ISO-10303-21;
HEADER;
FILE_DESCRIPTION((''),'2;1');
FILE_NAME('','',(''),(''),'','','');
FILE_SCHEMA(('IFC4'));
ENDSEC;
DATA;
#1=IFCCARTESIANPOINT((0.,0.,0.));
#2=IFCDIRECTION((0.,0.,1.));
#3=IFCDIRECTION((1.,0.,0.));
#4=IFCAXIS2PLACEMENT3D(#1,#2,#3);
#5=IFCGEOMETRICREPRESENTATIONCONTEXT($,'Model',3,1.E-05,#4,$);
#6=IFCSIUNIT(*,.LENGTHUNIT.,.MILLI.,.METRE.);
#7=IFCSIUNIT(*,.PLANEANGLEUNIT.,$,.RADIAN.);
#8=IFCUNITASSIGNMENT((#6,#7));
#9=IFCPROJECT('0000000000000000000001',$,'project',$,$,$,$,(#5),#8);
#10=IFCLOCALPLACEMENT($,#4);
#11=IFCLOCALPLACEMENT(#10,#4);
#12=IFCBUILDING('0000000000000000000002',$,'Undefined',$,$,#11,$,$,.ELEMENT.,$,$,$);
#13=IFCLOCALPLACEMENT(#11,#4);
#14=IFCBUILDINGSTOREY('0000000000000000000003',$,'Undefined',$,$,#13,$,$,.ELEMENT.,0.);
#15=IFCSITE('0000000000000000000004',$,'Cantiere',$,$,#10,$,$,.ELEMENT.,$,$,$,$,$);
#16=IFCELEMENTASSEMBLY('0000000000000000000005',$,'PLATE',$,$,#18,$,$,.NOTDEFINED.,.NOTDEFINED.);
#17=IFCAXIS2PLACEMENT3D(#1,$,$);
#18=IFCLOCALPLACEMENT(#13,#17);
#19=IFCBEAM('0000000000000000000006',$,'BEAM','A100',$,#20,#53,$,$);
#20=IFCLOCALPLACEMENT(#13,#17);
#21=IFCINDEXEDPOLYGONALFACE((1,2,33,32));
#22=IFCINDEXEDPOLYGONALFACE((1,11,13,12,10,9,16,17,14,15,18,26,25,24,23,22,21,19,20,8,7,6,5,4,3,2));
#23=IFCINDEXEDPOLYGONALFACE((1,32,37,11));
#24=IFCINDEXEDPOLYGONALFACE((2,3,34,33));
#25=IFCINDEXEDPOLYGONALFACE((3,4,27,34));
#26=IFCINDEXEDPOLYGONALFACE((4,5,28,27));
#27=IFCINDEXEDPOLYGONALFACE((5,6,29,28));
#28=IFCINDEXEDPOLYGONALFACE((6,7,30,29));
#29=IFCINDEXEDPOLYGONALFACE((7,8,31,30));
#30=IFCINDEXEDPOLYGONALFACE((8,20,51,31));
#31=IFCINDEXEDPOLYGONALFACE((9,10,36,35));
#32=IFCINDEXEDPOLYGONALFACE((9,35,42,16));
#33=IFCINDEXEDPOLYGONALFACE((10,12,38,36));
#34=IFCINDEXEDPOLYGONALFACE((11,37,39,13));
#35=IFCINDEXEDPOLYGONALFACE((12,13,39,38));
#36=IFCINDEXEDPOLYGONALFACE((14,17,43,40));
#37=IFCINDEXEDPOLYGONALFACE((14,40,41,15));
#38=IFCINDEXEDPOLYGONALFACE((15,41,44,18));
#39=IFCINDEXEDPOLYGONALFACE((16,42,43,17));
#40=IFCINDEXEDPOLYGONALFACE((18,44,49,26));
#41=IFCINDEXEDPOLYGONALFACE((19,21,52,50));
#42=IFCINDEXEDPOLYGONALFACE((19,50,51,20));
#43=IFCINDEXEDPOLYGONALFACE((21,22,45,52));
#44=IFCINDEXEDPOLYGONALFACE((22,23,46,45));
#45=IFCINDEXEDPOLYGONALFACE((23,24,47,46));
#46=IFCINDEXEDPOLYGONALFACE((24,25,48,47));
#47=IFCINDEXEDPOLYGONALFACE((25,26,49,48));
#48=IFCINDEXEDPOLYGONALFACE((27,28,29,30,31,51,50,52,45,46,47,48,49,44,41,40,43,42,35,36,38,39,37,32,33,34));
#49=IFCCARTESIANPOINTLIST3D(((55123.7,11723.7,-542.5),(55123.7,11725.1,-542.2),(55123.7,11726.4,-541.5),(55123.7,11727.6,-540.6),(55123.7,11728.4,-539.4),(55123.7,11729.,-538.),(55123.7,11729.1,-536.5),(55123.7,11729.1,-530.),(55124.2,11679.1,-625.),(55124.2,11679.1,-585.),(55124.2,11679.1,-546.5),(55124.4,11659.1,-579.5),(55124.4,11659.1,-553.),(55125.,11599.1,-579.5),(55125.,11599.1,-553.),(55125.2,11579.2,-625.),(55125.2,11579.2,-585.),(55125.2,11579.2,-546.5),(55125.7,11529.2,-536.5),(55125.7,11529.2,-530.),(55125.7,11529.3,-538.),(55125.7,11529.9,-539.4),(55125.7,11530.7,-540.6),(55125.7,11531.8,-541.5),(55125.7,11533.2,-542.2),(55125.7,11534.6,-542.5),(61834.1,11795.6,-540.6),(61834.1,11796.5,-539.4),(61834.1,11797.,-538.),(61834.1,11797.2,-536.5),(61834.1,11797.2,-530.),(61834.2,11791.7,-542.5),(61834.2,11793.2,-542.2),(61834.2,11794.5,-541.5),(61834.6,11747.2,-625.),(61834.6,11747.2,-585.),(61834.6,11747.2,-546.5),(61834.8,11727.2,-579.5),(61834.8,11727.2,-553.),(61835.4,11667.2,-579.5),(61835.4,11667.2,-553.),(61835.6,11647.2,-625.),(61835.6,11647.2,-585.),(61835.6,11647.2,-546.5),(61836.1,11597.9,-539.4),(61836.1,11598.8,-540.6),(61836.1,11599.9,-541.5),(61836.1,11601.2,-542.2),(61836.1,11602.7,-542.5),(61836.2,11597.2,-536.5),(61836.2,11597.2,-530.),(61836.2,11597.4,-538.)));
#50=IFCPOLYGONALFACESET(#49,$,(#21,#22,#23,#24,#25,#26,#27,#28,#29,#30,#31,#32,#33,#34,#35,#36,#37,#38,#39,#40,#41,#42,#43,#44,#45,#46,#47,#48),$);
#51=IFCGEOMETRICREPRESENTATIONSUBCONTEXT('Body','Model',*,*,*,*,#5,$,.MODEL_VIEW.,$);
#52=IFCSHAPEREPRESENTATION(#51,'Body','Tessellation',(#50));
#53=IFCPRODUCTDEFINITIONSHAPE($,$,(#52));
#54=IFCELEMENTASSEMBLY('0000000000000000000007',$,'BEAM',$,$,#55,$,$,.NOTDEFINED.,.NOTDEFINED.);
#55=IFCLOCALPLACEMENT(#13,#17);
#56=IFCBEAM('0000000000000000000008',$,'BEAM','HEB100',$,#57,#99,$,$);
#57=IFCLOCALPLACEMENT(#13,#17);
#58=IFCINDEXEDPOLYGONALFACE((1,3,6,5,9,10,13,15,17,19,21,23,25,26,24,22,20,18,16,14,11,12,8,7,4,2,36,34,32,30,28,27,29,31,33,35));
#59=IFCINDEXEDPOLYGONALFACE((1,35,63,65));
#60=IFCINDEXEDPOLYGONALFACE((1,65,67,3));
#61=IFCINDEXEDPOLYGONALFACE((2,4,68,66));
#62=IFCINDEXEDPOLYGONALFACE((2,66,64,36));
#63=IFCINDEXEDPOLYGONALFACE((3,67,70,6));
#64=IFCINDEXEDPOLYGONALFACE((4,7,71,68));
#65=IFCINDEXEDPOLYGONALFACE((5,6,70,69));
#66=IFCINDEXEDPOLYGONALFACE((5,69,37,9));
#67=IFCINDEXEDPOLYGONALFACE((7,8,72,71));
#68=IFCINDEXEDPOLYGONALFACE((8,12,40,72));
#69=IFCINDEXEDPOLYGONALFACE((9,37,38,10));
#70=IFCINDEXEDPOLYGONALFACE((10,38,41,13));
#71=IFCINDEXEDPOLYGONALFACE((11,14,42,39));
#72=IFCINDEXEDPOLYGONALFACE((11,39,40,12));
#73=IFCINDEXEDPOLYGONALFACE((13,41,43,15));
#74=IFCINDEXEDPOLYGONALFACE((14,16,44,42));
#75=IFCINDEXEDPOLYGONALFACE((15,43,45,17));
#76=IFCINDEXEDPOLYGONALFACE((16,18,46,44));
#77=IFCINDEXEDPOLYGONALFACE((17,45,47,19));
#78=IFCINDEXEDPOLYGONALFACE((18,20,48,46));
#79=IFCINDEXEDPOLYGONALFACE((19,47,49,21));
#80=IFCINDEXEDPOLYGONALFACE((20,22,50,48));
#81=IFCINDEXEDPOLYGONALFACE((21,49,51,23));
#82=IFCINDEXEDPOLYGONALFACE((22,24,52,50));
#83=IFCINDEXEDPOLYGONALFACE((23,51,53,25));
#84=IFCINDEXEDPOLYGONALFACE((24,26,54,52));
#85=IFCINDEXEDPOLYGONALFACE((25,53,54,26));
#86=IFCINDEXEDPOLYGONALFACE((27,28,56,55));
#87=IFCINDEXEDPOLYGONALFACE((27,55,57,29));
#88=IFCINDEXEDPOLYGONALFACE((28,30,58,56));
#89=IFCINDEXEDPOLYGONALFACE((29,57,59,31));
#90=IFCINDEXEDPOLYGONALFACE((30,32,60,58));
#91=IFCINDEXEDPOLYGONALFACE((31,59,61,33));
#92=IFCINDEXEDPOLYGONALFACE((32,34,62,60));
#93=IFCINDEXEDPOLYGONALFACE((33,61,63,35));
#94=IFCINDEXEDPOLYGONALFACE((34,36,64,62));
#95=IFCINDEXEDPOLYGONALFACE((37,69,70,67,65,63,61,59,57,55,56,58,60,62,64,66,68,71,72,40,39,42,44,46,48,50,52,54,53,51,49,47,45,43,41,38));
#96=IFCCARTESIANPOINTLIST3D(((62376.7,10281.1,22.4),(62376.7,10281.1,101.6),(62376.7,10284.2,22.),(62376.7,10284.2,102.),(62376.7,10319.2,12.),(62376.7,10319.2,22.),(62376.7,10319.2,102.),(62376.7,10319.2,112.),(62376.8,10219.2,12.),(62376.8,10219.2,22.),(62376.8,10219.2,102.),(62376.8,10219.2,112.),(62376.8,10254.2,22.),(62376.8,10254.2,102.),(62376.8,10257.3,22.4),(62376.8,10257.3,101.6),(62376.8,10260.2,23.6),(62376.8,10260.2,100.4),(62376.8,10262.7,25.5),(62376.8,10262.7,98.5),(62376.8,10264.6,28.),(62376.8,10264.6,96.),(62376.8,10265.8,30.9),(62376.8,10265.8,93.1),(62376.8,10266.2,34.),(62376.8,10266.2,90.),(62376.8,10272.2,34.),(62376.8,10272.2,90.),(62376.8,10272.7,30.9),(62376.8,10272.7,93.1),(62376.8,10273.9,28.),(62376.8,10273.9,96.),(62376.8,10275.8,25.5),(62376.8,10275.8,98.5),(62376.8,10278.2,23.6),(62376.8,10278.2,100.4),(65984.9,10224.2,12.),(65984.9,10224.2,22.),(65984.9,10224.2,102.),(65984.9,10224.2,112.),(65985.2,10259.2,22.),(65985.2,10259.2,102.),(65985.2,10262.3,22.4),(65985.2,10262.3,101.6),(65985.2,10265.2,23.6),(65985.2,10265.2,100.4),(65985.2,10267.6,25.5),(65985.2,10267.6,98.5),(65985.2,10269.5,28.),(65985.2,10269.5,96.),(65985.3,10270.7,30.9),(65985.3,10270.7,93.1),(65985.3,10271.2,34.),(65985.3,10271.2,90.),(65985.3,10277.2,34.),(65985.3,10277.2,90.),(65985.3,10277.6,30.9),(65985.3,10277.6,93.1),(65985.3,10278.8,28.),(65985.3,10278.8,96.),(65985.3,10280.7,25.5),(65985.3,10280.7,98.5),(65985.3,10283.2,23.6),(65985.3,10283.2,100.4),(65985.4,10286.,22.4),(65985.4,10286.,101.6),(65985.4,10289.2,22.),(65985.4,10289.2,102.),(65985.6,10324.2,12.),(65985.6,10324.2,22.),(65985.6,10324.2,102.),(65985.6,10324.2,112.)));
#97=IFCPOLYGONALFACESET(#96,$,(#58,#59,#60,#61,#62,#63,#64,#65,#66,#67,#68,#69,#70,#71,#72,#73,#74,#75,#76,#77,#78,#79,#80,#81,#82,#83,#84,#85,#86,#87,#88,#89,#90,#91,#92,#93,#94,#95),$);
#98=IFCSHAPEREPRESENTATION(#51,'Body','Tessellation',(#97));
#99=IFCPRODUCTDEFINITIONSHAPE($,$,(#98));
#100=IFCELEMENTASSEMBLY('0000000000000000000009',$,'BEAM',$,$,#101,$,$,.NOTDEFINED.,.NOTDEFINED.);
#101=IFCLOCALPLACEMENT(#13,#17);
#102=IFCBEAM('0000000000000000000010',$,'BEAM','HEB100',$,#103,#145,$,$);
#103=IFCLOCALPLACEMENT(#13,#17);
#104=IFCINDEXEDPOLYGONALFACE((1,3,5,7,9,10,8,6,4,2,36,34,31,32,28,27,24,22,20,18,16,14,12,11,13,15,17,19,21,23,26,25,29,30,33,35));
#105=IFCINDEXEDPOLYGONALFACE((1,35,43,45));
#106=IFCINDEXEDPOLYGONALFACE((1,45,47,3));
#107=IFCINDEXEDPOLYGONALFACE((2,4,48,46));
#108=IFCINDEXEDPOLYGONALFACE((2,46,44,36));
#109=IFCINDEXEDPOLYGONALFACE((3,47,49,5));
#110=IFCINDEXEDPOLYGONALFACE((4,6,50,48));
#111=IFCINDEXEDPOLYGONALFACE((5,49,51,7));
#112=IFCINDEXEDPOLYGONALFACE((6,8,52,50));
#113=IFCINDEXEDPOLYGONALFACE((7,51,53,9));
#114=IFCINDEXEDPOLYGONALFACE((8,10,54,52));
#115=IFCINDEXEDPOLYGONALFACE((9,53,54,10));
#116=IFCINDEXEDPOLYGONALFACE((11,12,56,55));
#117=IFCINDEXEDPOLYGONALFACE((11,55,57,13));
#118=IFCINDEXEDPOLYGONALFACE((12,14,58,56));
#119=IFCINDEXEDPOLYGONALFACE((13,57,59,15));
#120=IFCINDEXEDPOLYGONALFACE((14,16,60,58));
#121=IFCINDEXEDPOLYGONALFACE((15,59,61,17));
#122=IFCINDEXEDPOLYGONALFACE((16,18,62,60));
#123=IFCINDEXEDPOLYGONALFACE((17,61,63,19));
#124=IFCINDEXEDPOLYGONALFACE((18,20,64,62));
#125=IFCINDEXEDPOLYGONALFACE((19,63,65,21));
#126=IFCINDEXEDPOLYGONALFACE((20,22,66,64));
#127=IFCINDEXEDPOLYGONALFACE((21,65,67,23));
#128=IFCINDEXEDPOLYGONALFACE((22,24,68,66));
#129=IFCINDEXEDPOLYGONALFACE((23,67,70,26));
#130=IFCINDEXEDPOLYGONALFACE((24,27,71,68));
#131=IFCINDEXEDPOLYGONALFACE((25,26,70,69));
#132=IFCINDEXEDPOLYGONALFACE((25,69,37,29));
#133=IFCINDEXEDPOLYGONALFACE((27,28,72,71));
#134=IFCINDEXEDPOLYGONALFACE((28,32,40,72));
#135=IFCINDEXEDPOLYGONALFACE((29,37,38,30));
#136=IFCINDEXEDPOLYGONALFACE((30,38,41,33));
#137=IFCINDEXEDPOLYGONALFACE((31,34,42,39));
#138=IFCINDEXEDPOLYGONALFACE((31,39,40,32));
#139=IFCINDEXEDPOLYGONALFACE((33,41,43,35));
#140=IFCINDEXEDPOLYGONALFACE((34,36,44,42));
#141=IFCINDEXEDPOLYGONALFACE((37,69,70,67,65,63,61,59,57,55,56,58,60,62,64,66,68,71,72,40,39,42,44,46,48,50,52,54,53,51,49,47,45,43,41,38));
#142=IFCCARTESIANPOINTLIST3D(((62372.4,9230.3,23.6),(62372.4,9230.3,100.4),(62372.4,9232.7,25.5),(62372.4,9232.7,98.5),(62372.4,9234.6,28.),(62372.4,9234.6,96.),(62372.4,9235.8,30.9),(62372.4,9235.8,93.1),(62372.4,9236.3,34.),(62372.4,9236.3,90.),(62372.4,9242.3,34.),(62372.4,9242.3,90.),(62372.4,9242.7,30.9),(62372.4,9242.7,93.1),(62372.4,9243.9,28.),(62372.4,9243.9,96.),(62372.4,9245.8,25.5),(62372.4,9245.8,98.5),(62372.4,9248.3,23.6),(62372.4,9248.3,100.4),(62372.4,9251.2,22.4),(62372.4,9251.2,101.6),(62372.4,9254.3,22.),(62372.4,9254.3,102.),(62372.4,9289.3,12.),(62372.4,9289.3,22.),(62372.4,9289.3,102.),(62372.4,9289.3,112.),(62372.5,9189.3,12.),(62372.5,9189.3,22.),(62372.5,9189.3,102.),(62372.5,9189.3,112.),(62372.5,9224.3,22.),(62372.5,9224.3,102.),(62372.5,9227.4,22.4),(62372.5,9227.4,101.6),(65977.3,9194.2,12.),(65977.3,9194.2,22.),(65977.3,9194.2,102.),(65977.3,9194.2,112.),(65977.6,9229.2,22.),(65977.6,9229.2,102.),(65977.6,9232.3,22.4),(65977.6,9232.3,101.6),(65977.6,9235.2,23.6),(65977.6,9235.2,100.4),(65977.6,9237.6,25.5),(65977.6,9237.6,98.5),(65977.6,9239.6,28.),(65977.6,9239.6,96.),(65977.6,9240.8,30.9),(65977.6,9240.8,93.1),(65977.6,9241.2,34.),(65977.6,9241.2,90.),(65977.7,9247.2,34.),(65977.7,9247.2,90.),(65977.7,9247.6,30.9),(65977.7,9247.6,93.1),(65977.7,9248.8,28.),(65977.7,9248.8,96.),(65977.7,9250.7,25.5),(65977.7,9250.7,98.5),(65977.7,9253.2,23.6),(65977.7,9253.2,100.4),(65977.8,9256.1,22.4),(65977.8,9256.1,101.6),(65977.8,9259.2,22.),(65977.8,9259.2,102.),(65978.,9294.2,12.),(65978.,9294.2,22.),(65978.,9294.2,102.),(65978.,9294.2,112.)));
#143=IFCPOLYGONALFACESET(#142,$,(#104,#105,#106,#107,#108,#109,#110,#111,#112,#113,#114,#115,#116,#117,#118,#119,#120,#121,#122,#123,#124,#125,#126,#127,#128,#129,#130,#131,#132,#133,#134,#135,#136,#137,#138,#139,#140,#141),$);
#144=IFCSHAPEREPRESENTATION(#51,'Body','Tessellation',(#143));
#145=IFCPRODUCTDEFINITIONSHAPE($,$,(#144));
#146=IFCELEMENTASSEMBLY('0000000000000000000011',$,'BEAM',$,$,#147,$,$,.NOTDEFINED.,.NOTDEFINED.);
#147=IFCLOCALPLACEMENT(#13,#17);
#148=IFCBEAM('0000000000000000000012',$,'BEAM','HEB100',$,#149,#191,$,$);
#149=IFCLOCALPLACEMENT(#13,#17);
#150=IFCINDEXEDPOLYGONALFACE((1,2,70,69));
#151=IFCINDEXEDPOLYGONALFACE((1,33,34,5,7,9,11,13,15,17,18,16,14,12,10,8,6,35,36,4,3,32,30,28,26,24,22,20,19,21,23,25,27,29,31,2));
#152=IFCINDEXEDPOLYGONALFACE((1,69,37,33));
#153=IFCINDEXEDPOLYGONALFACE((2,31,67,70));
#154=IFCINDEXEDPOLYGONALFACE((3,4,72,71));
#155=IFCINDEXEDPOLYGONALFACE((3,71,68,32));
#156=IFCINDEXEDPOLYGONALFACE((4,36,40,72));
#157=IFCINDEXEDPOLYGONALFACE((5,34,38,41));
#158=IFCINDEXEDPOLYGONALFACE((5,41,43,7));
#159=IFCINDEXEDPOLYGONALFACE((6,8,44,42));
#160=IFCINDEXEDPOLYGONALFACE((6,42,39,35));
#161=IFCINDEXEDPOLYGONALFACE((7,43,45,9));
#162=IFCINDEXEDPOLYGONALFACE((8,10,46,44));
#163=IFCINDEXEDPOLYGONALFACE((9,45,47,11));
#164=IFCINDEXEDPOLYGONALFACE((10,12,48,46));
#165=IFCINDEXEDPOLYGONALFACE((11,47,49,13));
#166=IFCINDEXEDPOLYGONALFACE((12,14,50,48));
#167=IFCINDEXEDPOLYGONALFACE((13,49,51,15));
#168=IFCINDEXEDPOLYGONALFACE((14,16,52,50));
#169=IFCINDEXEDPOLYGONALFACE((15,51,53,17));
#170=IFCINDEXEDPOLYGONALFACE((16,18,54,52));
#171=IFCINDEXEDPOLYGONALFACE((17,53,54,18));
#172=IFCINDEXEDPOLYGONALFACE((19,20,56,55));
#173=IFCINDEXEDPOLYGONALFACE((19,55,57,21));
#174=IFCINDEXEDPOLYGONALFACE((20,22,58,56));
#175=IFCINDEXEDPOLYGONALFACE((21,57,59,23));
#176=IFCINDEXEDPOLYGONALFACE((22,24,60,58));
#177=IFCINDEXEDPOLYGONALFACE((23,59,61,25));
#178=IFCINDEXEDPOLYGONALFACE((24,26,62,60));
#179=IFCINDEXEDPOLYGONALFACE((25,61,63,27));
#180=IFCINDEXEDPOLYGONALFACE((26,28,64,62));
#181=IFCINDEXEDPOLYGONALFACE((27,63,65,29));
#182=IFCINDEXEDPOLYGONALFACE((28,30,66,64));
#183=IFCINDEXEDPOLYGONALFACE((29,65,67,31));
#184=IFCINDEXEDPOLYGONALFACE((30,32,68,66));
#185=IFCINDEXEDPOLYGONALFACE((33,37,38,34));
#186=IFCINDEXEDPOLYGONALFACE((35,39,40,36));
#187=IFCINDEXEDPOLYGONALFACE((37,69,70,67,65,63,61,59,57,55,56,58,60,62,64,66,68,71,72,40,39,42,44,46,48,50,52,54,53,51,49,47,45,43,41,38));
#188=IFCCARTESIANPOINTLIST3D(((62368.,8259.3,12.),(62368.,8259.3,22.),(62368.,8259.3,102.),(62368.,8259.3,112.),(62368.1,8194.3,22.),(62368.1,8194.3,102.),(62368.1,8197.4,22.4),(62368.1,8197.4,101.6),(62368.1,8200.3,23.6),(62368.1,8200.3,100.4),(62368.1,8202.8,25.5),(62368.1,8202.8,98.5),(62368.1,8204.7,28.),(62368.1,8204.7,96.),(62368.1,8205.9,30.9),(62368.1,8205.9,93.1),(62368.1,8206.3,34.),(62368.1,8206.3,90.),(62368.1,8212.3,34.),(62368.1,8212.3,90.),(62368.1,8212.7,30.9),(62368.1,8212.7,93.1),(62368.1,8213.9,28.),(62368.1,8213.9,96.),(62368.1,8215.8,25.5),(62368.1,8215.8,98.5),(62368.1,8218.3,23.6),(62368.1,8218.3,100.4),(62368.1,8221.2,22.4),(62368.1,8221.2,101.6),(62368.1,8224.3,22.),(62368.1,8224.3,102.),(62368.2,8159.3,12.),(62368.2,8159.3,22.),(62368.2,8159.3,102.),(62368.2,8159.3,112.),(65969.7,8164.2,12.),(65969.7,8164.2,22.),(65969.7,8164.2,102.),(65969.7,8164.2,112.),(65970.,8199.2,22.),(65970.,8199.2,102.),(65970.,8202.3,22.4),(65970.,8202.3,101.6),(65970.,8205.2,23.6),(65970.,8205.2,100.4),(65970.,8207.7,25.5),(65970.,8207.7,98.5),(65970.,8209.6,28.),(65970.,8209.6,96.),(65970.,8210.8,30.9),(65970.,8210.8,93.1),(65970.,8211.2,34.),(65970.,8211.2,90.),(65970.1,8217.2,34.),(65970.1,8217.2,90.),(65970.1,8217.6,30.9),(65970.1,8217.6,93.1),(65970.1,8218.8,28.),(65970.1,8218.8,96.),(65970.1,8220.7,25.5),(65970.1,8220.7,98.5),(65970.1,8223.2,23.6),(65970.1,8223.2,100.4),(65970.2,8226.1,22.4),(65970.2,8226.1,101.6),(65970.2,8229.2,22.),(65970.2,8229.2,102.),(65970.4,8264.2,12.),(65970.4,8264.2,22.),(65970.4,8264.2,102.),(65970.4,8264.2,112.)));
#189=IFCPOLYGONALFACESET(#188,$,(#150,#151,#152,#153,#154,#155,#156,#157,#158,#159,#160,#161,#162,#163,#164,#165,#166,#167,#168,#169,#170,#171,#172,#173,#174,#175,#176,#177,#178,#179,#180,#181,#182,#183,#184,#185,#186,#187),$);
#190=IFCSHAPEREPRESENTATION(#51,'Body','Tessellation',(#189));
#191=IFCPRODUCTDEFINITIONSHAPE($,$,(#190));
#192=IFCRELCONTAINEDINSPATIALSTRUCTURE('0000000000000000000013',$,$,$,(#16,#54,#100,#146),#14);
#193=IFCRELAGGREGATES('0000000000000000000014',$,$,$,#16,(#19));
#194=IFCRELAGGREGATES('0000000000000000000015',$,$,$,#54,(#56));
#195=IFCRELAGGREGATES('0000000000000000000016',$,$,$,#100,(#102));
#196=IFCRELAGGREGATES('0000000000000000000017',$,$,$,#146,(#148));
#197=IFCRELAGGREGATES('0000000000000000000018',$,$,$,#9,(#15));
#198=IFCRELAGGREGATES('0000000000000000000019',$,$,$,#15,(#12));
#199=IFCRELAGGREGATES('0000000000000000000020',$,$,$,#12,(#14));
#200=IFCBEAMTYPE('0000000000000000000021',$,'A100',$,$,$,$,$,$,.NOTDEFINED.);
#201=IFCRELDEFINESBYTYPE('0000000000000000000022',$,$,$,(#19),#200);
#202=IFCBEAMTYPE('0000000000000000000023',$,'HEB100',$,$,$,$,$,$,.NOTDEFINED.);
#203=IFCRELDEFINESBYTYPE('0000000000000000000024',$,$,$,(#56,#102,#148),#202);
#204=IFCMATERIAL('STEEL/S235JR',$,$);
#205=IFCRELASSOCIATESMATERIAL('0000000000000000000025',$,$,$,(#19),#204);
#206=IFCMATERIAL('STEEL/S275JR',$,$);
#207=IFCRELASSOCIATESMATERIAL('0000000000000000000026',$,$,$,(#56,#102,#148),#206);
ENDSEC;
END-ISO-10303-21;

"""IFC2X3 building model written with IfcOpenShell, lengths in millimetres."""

from ifc_helpers import new_model, si_unit, frame, origin_with_axes, origin_2d_with_axis, place, context, subcontext, project, spatial, polyline, i_section, outline, extrude, clip, halfspace, material, type_object, element, aggregate, save


model = new_model("IFC2X3")

# Units and contexts
model_context = context("Model", 3, precision=1e-05, world=origin_with_axes())
body_context = subcontext(model_context, "Body", "Model", "MODEL_VIEW")
ifc_project = project(units=[si_unit("LENGTHUNIT", "METRE", prefix="MILLI"), si_unit("PLANEANGLEUNIT", "RADIAN")], contexts=[model_context])

# Site, building, storey
site_placement = place(None, origin_with_axes())
site = spatial("IfcSite", under=ifc_project, at=site_placement, Name="Cantiere", CompositionType="ELEMENT")
building_placement = place(site_placement, origin_with_axes())
building = spatial("IfcBuilding", under=site, at=building_placement, Name="Undefined", CompositionType="ELEMENT")
storey_placement = place(building_placement, origin_with_axes())
storey = spatial("IfcBuildingStorey", under=building, at=storey_placement, Name="Undefined", CompositionType="ELEMENT", Elevation=0.0)

# Element assemblies, beams
ifc_material_1 = material(Name="STEEL/S275JR")
assembly_1_placement = place(storey_placement, origin_with_axes())
assembly_1 = element("IfcElementAssembly", 1, at=assembly_1_placement, inside=storey, Name="PLATE", AssemblyPlace="NOTDEFINED", PredefinedType="NOTDEFINED")
ifc_material_2 = material(Name="STEEL/S235JR")
beam_type_1 = type_object("IfcBeamType", Name="A100", PredefinedType="NOTDEFINED")
beam_1_placement = place(assembly_1_placement, frame((61835.1, 11697.2, -577.5), z_axis=(0.0, 0.000001, -1.0), x_axis=(-0.999949, -0.010139, 0.0)))
beam_1 = element("IfcBeam", 2, at=beam_1_placement, type_object=beam_type_1, material=ifc_material_2, Name="BEAM", Description="A100", context=body_context, shape_type="SweptSolid", body=[
    extrude(outline(polyline([(30.0, -24.5), (50.0, -31.0), (94.5, -35.0), (96.0, -35.3), (97.3, -36.0), (98.4, -36.9), (99.3, -38.1), (99.8, -39.5), (100.0, -41.0), (100.0, -47.5), (-100.0, -47.5), (-100.0, -41.0), (-99.8, -39.5), (-99.3, -38.1), (-98.4, -36.9), (-97.3, -36.0), (-96.0, -35.3), (-94.5, -35.0), (-50.0, -31.0), (-30.0, -24.5), (-30.0, 2.0), (-50.0, 7.5), (-50.0, 47.5), (50.0, 47.5), (50.0, 7.5), (30.0, 2.0), (30.0, -24.5)])), frame((6710.8, 0.0, 0.0), z_axis=(-1.0, 0.0, 0.0), x_axis=(0.0, -1.0, 0.0)), (0.0, 0.0, 1.0), 6710.8),
])
aggregate(assembly_1, [beam_1])
assembly_2_placement = place(storey_placement, origin_with_axes())
assembly_2 = element("IfcElementAssembly", 3, at=assembly_2_placement, inside=storey, Name="BEAM", AssemblyPlace="NOTDEFINED", PredefinedType="NOTDEFINED")
beam_type_2 = type_object("IfcBeamType", Name="HEB100", PredefinedType="NOTDEFINED")
beam_2_placement = place(assembly_2_placement, frame((62376.8, 10269.2, 62.0), z_axis=(0.0, 0.0, 1.0), x_axis=(0.999999, 0.001361, 0.0)))
beam_2 = element("IfcBeam", 4, at=beam_2_placement, type_object=beam_type_2, material=ifc_material_1, Name="BEAM", Description="HEB100", context=body_context, shape_type="Clipping", body=[
    clip(extrude(i_section(OverallWidth=100.0, OverallDepth=100.0, WebThickness=6.0, FlangeThickness=10.0, FilletRadius=12.0, at=origin_2d_with_axis()), frame((3680.2, 0.0, 0.0), z_axis=(-1.0, 0.0, 0.0), x_axis=(0.0, -1.0, 0.0)), (0.0, 0.0, 1.0), 3680.2), halfspace(frame((3609.0, 50.0, 50.0), z_axis=(0.999962, -0.008745, 0.0), x_axis=(0.0, 0.000001, -1.0)), False)),
])
assembly_3_placement = place(storey_placement, origin_with_axes())
assembly_3 = element("IfcElementAssembly", 5, at=assembly_3_placement, inside=storey, Name="BEAM", AssemblyPlace="NOTDEFINED", PredefinedType="NOTDEFINED")
beam_3_placement = place(assembly_3_placement, frame((62372.4, 9239.3, 62.0), z_axis=(0.0, 0.0, 1.0), x_axis=(0.999999, 0.001361, 0.0)))
beam_3 = element("IfcBeam", 6, at=beam_3_placement, type_object=beam_type_2, material=ifc_material_1, Name="BEAM", Description="HEB100", context=body_context, shape_type="Clipping", body=[
    clip(extrude(i_section(OverallWidth=100.0, OverallDepth=100.0, WebThickness=6.0, FlangeThickness=10.0, FilletRadius=12.0, at=origin_2d_with_axis()), frame((3680.2, 0.0, 0.0), z_axis=(-1.0, 0.0, 0.0), x_axis=(0.0, -1.0, 0.0)), (0.0, 0.0, 1.0), 3680.2), halfspace(frame((3605.7, 50.0, 50.0), z_axis=(0.999962, -0.008745, 0.0), x_axis=(0.0, 0.000001, -1.0)), False)),
])
assembly_4_placement = place(storey_placement, origin_with_axes())
assembly_4 = element("IfcElementAssembly", 7, at=assembly_4_placement, inside=storey, Name="BEAM", AssemblyPlace="NOTDEFINED", PredefinedType="NOTDEFINED")
beam_4_placement = place(assembly_4_placement, frame((62368.1, 8209.3, 62.0), z_axis=(0.0, 0.0, 1.0), x_axis=(0.999999, 0.001361, 0.0)))
beam_4 = element("IfcBeam", 8, at=beam_4_placement, type_object=beam_type_2, material=ifc_material_1, Name="BEAM", Description="HEB100", context=body_context, shape_type="Clipping", body=[
    clip(extrude(i_section(OverallWidth=100.0, OverallDepth=100.0, WebThickness=6.0, FlangeThickness=10.0, FilletRadius=12.0, at=origin_2d_with_axis()), frame((3680.2, 0.0, 0.0), z_axis=(-1.0, 0.0, 0.0), x_axis=(0.0, -1.0, 0.0)), (0.0, 0.0, 1.0), 3680.2), halfspace(frame((3602.4, 50.0, 50.0), z_axis=(0.999962, -0.008745, 0.0), x_axis=(0.0, 0.000001, -1.0)), False)),
])

aggregate(assembly_2, [beam_2])
aggregate(assembly_3, [beam_3])
aggregate(assembly_4, [beam_4])

save(model, "model.ifc")
